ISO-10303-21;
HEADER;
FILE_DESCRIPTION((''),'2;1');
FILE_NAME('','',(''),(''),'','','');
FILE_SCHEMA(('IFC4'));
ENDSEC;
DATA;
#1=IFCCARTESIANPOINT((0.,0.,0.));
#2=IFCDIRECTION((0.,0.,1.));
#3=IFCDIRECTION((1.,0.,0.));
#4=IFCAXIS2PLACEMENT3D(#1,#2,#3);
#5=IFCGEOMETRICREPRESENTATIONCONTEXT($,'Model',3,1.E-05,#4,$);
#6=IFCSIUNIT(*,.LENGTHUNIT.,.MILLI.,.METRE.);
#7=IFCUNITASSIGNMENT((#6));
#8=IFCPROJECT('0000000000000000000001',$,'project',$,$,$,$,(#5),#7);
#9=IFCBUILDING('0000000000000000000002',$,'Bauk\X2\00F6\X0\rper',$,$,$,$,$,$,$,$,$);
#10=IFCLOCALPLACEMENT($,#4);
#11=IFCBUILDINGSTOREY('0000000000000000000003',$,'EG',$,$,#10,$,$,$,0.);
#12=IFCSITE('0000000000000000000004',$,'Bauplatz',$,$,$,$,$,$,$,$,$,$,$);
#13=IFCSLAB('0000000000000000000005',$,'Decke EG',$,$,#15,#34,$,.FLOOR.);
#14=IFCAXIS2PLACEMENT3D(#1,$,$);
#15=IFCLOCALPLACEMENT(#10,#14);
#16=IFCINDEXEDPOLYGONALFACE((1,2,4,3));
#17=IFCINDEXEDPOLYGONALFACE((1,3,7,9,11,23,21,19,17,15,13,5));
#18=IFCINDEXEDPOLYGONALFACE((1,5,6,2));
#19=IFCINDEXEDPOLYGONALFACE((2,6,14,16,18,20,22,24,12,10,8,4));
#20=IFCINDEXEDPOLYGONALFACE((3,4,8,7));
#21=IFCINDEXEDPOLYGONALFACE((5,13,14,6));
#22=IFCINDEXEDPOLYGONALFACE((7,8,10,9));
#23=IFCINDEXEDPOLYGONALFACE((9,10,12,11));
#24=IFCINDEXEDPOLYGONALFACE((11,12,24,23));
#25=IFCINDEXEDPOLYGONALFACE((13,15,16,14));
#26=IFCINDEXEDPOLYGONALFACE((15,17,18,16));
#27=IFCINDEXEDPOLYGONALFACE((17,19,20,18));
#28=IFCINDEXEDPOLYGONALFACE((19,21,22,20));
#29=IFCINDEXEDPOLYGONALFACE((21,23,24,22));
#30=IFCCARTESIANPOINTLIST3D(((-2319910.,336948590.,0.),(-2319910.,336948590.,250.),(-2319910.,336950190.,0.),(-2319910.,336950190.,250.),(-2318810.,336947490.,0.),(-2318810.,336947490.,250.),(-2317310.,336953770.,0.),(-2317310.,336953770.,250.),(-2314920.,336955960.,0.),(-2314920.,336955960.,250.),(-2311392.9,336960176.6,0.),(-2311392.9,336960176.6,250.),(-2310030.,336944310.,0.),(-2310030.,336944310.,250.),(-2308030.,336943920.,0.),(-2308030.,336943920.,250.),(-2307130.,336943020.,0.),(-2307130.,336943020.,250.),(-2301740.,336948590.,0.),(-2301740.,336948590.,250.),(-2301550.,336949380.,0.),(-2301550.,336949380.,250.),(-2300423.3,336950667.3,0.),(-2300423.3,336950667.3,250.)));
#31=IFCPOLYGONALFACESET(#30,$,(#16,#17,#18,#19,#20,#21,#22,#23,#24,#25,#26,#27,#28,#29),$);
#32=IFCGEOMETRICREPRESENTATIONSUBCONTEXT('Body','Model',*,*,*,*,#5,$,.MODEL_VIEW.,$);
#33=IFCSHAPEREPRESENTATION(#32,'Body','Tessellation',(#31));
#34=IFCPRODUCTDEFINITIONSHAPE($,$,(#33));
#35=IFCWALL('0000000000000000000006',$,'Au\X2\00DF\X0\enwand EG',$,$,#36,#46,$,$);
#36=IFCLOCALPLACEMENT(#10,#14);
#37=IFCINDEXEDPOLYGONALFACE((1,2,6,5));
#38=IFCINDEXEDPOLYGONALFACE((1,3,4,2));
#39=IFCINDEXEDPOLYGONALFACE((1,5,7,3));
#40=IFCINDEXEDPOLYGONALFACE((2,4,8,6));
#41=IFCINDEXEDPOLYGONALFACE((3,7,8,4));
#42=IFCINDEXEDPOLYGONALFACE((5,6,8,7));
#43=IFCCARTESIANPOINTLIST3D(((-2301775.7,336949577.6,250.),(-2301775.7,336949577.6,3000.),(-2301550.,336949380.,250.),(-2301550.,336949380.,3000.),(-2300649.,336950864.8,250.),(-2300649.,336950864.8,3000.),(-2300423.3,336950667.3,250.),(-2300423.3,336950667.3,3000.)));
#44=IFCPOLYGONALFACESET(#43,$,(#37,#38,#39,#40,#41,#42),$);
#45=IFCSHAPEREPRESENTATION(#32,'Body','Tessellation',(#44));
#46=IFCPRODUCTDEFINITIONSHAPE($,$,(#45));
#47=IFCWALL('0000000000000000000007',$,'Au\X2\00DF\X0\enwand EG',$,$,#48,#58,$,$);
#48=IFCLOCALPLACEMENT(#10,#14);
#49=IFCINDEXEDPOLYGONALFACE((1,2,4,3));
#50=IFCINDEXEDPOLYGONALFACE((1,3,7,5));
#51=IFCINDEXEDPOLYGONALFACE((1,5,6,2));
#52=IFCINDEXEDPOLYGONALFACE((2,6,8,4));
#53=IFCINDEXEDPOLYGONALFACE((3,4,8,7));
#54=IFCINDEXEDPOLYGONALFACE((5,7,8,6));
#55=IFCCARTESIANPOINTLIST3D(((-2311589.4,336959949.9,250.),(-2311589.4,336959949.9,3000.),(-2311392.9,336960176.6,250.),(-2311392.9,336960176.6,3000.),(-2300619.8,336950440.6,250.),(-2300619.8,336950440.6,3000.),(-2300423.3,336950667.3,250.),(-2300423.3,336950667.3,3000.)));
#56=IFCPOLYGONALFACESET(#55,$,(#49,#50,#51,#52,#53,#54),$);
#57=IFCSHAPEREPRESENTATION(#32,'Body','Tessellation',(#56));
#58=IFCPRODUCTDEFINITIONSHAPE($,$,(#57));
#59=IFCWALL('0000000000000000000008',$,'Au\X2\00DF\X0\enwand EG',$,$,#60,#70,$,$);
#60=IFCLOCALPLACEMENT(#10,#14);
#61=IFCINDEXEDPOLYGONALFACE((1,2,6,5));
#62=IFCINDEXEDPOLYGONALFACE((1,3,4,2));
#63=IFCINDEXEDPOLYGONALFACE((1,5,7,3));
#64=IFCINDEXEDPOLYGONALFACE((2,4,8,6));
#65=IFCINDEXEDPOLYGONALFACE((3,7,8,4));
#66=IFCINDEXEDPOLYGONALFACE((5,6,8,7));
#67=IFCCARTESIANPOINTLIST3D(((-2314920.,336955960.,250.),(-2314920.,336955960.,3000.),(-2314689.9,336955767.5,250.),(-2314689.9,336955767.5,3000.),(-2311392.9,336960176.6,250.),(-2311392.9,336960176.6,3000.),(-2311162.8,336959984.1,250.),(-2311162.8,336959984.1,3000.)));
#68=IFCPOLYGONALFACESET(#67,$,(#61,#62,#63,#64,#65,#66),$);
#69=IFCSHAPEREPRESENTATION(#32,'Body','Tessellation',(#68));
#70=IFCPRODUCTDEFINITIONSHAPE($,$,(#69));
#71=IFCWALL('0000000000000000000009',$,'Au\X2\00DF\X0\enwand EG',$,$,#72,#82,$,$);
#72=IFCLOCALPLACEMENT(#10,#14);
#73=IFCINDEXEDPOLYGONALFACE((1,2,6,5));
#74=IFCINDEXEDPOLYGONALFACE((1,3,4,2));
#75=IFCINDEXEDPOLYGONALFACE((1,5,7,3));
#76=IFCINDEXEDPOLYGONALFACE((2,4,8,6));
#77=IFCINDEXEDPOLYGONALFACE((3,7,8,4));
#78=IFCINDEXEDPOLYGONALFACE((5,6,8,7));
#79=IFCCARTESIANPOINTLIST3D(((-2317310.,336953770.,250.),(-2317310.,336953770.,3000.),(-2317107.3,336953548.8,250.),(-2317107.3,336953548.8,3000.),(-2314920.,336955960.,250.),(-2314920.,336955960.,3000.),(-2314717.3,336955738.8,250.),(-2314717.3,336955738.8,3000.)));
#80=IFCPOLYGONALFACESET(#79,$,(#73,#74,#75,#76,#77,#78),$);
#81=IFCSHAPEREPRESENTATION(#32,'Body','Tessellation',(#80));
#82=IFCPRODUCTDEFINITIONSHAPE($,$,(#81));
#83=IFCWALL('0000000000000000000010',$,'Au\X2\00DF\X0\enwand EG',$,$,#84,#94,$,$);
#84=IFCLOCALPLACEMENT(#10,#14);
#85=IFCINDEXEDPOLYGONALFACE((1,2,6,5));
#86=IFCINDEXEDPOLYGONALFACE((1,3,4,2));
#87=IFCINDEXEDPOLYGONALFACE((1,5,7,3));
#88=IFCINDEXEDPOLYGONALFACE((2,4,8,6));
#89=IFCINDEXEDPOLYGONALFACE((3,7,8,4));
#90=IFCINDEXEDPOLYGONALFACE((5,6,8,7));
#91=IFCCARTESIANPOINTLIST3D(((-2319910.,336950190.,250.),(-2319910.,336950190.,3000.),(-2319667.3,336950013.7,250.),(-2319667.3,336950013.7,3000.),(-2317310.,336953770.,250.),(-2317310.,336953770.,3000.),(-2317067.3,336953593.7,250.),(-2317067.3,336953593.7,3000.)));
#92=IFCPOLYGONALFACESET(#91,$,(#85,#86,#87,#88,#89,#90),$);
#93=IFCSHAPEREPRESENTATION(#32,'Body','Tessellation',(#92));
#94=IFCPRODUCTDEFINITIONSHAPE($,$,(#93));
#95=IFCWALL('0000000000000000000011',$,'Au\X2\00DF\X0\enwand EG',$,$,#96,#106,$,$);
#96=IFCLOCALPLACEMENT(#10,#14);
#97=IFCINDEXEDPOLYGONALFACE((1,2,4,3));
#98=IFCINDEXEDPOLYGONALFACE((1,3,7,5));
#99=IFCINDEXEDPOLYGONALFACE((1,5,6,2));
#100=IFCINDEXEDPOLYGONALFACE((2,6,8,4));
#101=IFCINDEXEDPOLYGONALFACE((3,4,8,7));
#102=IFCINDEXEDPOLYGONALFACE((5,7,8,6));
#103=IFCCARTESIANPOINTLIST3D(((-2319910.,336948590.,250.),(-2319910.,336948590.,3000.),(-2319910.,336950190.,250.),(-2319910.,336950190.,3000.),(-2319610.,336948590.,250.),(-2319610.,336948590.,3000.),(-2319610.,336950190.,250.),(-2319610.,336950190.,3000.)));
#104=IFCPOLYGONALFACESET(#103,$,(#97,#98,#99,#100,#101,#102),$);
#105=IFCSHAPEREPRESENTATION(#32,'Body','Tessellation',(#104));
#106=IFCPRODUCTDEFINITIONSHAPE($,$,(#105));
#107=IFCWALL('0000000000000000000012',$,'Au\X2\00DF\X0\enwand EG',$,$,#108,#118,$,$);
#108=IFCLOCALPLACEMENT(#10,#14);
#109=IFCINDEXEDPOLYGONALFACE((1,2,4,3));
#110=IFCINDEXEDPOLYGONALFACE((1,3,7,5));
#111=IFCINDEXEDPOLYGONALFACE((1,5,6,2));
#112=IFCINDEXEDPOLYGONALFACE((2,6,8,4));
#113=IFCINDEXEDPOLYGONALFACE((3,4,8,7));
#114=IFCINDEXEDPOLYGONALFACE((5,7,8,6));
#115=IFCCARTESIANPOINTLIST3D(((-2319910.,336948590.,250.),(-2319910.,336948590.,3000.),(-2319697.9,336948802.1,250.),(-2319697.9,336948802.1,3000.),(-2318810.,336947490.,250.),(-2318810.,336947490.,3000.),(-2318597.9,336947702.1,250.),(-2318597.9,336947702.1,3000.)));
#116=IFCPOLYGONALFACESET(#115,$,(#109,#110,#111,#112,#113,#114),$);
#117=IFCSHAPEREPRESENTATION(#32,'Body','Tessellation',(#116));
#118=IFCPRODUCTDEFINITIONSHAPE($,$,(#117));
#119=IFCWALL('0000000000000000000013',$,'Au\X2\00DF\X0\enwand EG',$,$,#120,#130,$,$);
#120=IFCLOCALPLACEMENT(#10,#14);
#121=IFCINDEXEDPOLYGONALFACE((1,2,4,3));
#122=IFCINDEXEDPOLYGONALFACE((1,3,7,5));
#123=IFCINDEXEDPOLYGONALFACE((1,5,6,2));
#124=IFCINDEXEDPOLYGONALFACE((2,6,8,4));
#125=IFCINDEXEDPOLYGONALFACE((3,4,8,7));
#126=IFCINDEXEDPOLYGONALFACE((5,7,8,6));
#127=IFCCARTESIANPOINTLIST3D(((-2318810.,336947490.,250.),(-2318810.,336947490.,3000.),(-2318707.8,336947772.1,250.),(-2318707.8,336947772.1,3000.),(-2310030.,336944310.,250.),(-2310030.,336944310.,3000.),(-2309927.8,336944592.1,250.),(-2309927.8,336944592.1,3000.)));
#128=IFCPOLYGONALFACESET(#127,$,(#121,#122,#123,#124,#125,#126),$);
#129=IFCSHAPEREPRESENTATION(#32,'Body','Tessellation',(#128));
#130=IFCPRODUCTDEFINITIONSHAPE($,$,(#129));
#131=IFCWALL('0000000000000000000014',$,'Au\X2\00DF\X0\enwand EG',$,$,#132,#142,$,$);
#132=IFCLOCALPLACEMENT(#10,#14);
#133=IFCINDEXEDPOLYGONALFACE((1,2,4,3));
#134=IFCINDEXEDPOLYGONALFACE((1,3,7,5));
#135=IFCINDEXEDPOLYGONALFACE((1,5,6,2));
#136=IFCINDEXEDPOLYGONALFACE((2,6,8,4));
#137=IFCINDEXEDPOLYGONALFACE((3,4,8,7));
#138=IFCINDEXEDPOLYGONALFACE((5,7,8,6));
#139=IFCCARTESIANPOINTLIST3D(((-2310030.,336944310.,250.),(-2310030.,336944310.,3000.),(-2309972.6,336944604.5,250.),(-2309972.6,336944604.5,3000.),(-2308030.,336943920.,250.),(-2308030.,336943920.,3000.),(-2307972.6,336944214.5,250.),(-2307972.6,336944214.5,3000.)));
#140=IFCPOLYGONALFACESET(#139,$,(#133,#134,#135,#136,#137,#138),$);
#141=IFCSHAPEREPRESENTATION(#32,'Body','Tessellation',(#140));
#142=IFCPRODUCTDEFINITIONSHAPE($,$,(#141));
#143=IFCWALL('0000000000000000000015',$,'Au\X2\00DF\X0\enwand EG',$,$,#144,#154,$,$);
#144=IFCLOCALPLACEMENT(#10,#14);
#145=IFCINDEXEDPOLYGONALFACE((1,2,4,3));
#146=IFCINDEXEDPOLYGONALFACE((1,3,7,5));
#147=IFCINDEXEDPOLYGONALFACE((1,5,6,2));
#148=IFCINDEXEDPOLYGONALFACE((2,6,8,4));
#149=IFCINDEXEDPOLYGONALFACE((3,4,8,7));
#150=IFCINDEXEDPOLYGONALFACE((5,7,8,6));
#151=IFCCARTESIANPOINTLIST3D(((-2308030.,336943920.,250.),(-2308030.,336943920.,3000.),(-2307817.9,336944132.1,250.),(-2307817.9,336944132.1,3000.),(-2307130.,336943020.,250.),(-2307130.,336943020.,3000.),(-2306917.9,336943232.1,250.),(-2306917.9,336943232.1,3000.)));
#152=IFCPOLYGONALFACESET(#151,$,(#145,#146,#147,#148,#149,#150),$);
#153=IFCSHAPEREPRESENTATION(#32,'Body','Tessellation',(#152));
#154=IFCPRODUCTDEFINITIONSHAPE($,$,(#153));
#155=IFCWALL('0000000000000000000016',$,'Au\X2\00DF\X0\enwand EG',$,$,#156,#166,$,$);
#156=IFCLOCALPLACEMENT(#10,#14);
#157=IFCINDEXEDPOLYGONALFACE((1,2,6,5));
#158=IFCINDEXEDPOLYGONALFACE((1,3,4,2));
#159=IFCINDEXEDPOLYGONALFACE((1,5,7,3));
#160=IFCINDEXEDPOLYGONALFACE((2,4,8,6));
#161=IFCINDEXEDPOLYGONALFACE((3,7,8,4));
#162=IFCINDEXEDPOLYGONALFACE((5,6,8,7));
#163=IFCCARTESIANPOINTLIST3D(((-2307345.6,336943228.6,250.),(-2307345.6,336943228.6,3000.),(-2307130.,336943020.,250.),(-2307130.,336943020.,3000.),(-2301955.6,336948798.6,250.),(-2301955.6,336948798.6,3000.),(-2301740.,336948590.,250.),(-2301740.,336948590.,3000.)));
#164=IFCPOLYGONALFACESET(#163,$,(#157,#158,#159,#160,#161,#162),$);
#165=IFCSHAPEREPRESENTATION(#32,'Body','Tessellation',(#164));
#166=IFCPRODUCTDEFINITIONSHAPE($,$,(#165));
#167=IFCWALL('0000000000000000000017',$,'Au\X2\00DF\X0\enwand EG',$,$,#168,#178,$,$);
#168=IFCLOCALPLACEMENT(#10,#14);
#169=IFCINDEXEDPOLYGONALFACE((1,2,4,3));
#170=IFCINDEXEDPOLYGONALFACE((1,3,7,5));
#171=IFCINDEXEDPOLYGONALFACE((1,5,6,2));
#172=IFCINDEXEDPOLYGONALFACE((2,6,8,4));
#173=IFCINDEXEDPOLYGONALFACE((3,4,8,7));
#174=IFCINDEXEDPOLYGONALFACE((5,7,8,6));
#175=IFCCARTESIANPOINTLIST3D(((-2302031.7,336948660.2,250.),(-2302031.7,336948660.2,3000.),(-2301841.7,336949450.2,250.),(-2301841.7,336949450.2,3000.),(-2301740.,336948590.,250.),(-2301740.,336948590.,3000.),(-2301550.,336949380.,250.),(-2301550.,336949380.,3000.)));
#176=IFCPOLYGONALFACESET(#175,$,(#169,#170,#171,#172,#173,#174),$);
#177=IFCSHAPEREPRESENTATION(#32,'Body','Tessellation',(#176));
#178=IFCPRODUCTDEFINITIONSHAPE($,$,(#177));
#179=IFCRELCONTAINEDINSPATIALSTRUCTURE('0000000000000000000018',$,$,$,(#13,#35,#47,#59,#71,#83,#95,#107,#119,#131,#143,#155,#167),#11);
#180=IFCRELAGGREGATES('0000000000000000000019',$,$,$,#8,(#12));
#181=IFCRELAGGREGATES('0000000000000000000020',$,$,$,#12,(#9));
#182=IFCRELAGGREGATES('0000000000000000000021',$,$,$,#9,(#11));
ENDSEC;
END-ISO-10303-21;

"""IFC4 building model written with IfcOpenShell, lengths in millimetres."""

from ifc_helpers import new_model, si_unit, frame, origin_with_axes, place, context, subcontext, project, spatial, indexed_curve, outline, extrude, element, save


model = new_model("IFC4")

# Units and contexts
model_context = context("Model", 3, precision=1e-05, world=origin_with_axes())
body_context = subcontext(model_context, "Body", "Model", "MODEL_VIEW")
ifc_project = project(units=[si_unit("LENGTHUNIT", "METRE", prefix="MILLI")], contexts=[model_context])

# Site, building, storey
site = spatial("IfcSite", under=ifc_project, Name="Bauplatz")
building = spatial("IfcBuilding", under=site, Name="Baukörper")
storey_placement = place(None, origin_with_axes())
storey = spatial("IfcBuildingStorey", under=building, at=storey_placement, Name="EG", Elevation=0.0)

# Slab
slab_placement = place(storey_placement, origin_with_axes())
element("IfcSlab", 1, at=slab_placement, inside=storey, Name="Decke EG", PredefinedType="FLOOR", context=body_context, shape_type="SweptSolid", body=[
    extrude(outline(indexed_curve([(-2301550.0, 336949380.0), (-2301740.0, 336948590.0), (-2307130.0, 336943020.0), (-2308030.0, 336943920.0), (-2310030.0, 336944310.0), (-2318810.0, 336947490.0), (-2319910.0, 336948590.0), (-2319910.0, 336950190.0), (-2317310.0, 336953770.0), (-2314920.0, 336955960.0), (-2311392.9, 336960176.6), (-2300423.3, 336950667.3)])), None, (0.0, 0.0, 1.0), 250.0),
])

# Walls
wall_1_placement = place(storey_placement, frame((-2301550.0, 336949380.0, 250.0), z_axis=(0.0, 0.0, 1.0), x_axis=(0.658621, 0.752475, 0.0)))
element("IfcWall", 2, at=wall_1_placement, inside=storey, Name="Außenwand EG", context=body_context, shape_type="SweptSolid", body=[
    extrude(outline(indexed_curve([(0.0, 0.0), (0.0, 300.0), (1710.7, 300.0), (1710.7, 0.0), (0.0, 0.0)], self_intersect=False)), origin_with_axes(), (0.0, 0.0, 1.0), 2750.0),
])
wall_2_placement = place(storey_placement, frame((-2300423.3, 336950667.3, 250.0), z_axis=(0.0, 0.0, 1.0), x_axis=(-0.75561, 0.655022, 0.0)))
element("IfcWall", 3, at=wall_2_placement, inside=storey, Name="Außenwand EG", context=body_context, shape_type="SweptSolid", body=[
    extrude(outline(indexed_curve([(0.0, 0.0), (0.0, 300.0), (14517.6, 300.0), (14517.6, 0.0), (0.0, 0.0)], self_intersect=False)), origin_with_axes(), (0.0, 0.0, 1.0), 2750.0),
])
wall_3_placement = place(storey_placement, frame((-2311392.9, 336960176.6, 250.0), z_axis=(0.0, 0.0, 1.0), x_axis=(-0.641607, -0.767034, 0.0)))
element("IfcWall", 4, at=wall_3_placement, inside=storey, Name="Außenwand EG", context=body_context, shape_type="SweptSolid", body=[
    extrude(outline(indexed_curve([(0.0, 0.0), (0.0, 300.0), (5497.3, 300.0), (5497.3, 0.0), (0.0, 0.0)], self_intersect=False)), origin_with_axes(), (0.0, 0.0, 1.0), 2750.0),
])
wall_4_placement = place(storey_placement, frame((-2314920.0, 336955960.0, 250.0), z_axis=(0.0, 0.0, 1.0), x_axis=(-0.737282, -0.675585, 0.0)))
element("IfcWall", 5, at=wall_4_placement, inside=storey, Name="Außenwand EG", context=body_context, shape_type="SweptSolid", body=[
    extrude(outline(indexed_curve([(0.0, 0.0), (0.0, 300.0), (3241.6, 300.0), (3241.6, 0.0), (0.0, 0.0)], self_intersect=False)), origin_with_axes(), (0.0, 0.0, 1.0), 2750.0),
])
wall_5_placement = place(storey_placement, frame((-2317310.0, 336953770.0, 250.0), z_axis=(0.0, 0.0, 1.0), x_axis=(-0.587634, -0.809127, 0.0)))
element("IfcWall", 6, at=wall_5_placement, inside=storey, Name="Außenwand EG", context=body_context, shape_type="SweptSolid", body=[
    extrude(outline(indexed_curve([(0.0, 0.0), (0.0, 300.0), (4424.5, 300.0), (4424.5, 0.0), (0.0, 0.0)], self_intersect=False)), origin_with_axes(), (0.0, 0.0, 1.0), 2750.0),
])
wall_6_placement = place(storey_placement, frame((-2319910.0, 336950190.0, 250.0), z_axis=(0.0, 0.0, 1.0), x_axis=(0.0, -1.0, 0.0)))
element("IfcWall", 7, at=wall_6_placement, inside=storey, Name="Außenwand EG", context=body_context, shape_type="SweptSolid", body=[
    extrude(outline(indexed_curve([(0.0, 0.0), (0.0, 300.0), (1600.0, 300.0), (1600.0, 0.0), (0.0, 0.0)], self_intersect=False)), origin_with_axes(), (0.0, 0.0, 1.0), 2750.0),
])
wall_7_placement = place(storey_placement, frame((-2319910.0, 336948590.0, 250.0), z_axis=(0.0, 0.0, 1.0), x_axis=(0.707107, -0.707107, 0.0)))
element("IfcWall", 8, at=wall_7_placement, inside=storey, Name="Außenwand EG", context=body_context, shape_type="SweptSolid", body=[
    extrude(outline(indexed_curve([(0.0, 0.0), (0.0, 300.0), (1555.6, 300.0), (1555.6, 0.0), (0.0, 0.0)], self_intersect=False)), origin_with_axes(), (0.0, 0.0, 1.0), 2750.0),
])
wall_8_placement = place(storey_placement, frame((-2318810.0, 336947490.0, 250.0), z_axis=(0.0, 0.0, 1.0), x_axis=(0.94023, -0.340539, 0.0)))
element("IfcWall", 9, at=wall_8_placement, inside=storey, Name="Außenwand EG", context=body_context, shape_type="SweptSolid", body=[
    extrude(outline(indexed_curve([(0.0, 0.0), (0.0, 300.0), (9338.1, 300.0), (9338.1, 0.0), (0.0, 0.0)], self_intersect=False)), origin_with_axes(), (0.0, 0.0, 1.0), 2750.0),
])
wall_9_placement = place(storey_placement, frame((-2310030.0, 336944310.0, 250.0), z_axis=(0.0, 0.0, 1.0), x_axis=(0.981513, -0.191395, 0.0)))
element("IfcWall", 10, at=wall_9_placement, inside=storey, Name="Außenwand EG", context=body_context, shape_type="SweptSolid", body=[
    extrude(outline(indexed_curve([(0.0, 0.0), (0.0, 300.0), (2037.7, 300.0), (2037.7, 0.0), (0.0, 0.0)], self_intersect=False)), origin_with_axes(), (0.0, 0.0, 1.0), 2750.0),
])
wall_10_placement = place(storey_placement, frame((-2308030.0, 336943920.0, 250.0), z_axis=(0.0, 0.0, 1.0), x_axis=(0.707107, -0.707107, 0.0)))
element("IfcWall", 11, at=wall_10_placement, inside=storey, Name="Außenwand EG", context=body_context, shape_type="SweptSolid", body=[
    extrude(outline(indexed_curve([(0.0, 0.0), (0.0, 300.0), (1272.8, 300.0), (1272.8, 0.0), (0.0, 0.0)], self_intersect=False)), origin_with_axes(), (0.0, 0.0, 1.0), 2750.0),
])
wall_11_placement = place(storey_placement, frame((-2307130.0, 336943020.0, 250.0), z_axis=(0.0, 0.0, 1.0), x_axis=(0.6954, 0.718623, 0.0)))
element("IfcWall", 12, at=wall_11_placement, inside=storey, Name="Außenwand EG", context=body_context, shape_type="SweptSolid", body=[
    extrude(outline(indexed_curve([(0.0, 0.0), (0.0, 300.0), (7750.9, 300.0), (7750.9, 0.0), (0.0, 0.0)], self_intersect=False)), origin_with_axes(), (0.0, 0.0, 1.0), 2750.0),
])
wall_12_placement = place(storey_placement, frame((-2301740.0, 336948590.0, 250.0), z_axis=(0.0, 0.0, 1.0), x_axis=(0.233838, 0.972275, 0.0)))
element("IfcWall", 13, at=wall_12_placement, inside=storey, Name="Außenwand EG", context=body_context, shape_type="SweptSolid", body=[
    extrude(outline(indexed_curve([(0.0, 0.0), (0.0, 300.0), (812.5, 300.0), (812.5, 0.0), (0.0, 0.0)], self_intersect=False)), origin_with_axes(), (0.0, 0.0, 1.0), 2750.0),
])

save(model, "model.ifc")
